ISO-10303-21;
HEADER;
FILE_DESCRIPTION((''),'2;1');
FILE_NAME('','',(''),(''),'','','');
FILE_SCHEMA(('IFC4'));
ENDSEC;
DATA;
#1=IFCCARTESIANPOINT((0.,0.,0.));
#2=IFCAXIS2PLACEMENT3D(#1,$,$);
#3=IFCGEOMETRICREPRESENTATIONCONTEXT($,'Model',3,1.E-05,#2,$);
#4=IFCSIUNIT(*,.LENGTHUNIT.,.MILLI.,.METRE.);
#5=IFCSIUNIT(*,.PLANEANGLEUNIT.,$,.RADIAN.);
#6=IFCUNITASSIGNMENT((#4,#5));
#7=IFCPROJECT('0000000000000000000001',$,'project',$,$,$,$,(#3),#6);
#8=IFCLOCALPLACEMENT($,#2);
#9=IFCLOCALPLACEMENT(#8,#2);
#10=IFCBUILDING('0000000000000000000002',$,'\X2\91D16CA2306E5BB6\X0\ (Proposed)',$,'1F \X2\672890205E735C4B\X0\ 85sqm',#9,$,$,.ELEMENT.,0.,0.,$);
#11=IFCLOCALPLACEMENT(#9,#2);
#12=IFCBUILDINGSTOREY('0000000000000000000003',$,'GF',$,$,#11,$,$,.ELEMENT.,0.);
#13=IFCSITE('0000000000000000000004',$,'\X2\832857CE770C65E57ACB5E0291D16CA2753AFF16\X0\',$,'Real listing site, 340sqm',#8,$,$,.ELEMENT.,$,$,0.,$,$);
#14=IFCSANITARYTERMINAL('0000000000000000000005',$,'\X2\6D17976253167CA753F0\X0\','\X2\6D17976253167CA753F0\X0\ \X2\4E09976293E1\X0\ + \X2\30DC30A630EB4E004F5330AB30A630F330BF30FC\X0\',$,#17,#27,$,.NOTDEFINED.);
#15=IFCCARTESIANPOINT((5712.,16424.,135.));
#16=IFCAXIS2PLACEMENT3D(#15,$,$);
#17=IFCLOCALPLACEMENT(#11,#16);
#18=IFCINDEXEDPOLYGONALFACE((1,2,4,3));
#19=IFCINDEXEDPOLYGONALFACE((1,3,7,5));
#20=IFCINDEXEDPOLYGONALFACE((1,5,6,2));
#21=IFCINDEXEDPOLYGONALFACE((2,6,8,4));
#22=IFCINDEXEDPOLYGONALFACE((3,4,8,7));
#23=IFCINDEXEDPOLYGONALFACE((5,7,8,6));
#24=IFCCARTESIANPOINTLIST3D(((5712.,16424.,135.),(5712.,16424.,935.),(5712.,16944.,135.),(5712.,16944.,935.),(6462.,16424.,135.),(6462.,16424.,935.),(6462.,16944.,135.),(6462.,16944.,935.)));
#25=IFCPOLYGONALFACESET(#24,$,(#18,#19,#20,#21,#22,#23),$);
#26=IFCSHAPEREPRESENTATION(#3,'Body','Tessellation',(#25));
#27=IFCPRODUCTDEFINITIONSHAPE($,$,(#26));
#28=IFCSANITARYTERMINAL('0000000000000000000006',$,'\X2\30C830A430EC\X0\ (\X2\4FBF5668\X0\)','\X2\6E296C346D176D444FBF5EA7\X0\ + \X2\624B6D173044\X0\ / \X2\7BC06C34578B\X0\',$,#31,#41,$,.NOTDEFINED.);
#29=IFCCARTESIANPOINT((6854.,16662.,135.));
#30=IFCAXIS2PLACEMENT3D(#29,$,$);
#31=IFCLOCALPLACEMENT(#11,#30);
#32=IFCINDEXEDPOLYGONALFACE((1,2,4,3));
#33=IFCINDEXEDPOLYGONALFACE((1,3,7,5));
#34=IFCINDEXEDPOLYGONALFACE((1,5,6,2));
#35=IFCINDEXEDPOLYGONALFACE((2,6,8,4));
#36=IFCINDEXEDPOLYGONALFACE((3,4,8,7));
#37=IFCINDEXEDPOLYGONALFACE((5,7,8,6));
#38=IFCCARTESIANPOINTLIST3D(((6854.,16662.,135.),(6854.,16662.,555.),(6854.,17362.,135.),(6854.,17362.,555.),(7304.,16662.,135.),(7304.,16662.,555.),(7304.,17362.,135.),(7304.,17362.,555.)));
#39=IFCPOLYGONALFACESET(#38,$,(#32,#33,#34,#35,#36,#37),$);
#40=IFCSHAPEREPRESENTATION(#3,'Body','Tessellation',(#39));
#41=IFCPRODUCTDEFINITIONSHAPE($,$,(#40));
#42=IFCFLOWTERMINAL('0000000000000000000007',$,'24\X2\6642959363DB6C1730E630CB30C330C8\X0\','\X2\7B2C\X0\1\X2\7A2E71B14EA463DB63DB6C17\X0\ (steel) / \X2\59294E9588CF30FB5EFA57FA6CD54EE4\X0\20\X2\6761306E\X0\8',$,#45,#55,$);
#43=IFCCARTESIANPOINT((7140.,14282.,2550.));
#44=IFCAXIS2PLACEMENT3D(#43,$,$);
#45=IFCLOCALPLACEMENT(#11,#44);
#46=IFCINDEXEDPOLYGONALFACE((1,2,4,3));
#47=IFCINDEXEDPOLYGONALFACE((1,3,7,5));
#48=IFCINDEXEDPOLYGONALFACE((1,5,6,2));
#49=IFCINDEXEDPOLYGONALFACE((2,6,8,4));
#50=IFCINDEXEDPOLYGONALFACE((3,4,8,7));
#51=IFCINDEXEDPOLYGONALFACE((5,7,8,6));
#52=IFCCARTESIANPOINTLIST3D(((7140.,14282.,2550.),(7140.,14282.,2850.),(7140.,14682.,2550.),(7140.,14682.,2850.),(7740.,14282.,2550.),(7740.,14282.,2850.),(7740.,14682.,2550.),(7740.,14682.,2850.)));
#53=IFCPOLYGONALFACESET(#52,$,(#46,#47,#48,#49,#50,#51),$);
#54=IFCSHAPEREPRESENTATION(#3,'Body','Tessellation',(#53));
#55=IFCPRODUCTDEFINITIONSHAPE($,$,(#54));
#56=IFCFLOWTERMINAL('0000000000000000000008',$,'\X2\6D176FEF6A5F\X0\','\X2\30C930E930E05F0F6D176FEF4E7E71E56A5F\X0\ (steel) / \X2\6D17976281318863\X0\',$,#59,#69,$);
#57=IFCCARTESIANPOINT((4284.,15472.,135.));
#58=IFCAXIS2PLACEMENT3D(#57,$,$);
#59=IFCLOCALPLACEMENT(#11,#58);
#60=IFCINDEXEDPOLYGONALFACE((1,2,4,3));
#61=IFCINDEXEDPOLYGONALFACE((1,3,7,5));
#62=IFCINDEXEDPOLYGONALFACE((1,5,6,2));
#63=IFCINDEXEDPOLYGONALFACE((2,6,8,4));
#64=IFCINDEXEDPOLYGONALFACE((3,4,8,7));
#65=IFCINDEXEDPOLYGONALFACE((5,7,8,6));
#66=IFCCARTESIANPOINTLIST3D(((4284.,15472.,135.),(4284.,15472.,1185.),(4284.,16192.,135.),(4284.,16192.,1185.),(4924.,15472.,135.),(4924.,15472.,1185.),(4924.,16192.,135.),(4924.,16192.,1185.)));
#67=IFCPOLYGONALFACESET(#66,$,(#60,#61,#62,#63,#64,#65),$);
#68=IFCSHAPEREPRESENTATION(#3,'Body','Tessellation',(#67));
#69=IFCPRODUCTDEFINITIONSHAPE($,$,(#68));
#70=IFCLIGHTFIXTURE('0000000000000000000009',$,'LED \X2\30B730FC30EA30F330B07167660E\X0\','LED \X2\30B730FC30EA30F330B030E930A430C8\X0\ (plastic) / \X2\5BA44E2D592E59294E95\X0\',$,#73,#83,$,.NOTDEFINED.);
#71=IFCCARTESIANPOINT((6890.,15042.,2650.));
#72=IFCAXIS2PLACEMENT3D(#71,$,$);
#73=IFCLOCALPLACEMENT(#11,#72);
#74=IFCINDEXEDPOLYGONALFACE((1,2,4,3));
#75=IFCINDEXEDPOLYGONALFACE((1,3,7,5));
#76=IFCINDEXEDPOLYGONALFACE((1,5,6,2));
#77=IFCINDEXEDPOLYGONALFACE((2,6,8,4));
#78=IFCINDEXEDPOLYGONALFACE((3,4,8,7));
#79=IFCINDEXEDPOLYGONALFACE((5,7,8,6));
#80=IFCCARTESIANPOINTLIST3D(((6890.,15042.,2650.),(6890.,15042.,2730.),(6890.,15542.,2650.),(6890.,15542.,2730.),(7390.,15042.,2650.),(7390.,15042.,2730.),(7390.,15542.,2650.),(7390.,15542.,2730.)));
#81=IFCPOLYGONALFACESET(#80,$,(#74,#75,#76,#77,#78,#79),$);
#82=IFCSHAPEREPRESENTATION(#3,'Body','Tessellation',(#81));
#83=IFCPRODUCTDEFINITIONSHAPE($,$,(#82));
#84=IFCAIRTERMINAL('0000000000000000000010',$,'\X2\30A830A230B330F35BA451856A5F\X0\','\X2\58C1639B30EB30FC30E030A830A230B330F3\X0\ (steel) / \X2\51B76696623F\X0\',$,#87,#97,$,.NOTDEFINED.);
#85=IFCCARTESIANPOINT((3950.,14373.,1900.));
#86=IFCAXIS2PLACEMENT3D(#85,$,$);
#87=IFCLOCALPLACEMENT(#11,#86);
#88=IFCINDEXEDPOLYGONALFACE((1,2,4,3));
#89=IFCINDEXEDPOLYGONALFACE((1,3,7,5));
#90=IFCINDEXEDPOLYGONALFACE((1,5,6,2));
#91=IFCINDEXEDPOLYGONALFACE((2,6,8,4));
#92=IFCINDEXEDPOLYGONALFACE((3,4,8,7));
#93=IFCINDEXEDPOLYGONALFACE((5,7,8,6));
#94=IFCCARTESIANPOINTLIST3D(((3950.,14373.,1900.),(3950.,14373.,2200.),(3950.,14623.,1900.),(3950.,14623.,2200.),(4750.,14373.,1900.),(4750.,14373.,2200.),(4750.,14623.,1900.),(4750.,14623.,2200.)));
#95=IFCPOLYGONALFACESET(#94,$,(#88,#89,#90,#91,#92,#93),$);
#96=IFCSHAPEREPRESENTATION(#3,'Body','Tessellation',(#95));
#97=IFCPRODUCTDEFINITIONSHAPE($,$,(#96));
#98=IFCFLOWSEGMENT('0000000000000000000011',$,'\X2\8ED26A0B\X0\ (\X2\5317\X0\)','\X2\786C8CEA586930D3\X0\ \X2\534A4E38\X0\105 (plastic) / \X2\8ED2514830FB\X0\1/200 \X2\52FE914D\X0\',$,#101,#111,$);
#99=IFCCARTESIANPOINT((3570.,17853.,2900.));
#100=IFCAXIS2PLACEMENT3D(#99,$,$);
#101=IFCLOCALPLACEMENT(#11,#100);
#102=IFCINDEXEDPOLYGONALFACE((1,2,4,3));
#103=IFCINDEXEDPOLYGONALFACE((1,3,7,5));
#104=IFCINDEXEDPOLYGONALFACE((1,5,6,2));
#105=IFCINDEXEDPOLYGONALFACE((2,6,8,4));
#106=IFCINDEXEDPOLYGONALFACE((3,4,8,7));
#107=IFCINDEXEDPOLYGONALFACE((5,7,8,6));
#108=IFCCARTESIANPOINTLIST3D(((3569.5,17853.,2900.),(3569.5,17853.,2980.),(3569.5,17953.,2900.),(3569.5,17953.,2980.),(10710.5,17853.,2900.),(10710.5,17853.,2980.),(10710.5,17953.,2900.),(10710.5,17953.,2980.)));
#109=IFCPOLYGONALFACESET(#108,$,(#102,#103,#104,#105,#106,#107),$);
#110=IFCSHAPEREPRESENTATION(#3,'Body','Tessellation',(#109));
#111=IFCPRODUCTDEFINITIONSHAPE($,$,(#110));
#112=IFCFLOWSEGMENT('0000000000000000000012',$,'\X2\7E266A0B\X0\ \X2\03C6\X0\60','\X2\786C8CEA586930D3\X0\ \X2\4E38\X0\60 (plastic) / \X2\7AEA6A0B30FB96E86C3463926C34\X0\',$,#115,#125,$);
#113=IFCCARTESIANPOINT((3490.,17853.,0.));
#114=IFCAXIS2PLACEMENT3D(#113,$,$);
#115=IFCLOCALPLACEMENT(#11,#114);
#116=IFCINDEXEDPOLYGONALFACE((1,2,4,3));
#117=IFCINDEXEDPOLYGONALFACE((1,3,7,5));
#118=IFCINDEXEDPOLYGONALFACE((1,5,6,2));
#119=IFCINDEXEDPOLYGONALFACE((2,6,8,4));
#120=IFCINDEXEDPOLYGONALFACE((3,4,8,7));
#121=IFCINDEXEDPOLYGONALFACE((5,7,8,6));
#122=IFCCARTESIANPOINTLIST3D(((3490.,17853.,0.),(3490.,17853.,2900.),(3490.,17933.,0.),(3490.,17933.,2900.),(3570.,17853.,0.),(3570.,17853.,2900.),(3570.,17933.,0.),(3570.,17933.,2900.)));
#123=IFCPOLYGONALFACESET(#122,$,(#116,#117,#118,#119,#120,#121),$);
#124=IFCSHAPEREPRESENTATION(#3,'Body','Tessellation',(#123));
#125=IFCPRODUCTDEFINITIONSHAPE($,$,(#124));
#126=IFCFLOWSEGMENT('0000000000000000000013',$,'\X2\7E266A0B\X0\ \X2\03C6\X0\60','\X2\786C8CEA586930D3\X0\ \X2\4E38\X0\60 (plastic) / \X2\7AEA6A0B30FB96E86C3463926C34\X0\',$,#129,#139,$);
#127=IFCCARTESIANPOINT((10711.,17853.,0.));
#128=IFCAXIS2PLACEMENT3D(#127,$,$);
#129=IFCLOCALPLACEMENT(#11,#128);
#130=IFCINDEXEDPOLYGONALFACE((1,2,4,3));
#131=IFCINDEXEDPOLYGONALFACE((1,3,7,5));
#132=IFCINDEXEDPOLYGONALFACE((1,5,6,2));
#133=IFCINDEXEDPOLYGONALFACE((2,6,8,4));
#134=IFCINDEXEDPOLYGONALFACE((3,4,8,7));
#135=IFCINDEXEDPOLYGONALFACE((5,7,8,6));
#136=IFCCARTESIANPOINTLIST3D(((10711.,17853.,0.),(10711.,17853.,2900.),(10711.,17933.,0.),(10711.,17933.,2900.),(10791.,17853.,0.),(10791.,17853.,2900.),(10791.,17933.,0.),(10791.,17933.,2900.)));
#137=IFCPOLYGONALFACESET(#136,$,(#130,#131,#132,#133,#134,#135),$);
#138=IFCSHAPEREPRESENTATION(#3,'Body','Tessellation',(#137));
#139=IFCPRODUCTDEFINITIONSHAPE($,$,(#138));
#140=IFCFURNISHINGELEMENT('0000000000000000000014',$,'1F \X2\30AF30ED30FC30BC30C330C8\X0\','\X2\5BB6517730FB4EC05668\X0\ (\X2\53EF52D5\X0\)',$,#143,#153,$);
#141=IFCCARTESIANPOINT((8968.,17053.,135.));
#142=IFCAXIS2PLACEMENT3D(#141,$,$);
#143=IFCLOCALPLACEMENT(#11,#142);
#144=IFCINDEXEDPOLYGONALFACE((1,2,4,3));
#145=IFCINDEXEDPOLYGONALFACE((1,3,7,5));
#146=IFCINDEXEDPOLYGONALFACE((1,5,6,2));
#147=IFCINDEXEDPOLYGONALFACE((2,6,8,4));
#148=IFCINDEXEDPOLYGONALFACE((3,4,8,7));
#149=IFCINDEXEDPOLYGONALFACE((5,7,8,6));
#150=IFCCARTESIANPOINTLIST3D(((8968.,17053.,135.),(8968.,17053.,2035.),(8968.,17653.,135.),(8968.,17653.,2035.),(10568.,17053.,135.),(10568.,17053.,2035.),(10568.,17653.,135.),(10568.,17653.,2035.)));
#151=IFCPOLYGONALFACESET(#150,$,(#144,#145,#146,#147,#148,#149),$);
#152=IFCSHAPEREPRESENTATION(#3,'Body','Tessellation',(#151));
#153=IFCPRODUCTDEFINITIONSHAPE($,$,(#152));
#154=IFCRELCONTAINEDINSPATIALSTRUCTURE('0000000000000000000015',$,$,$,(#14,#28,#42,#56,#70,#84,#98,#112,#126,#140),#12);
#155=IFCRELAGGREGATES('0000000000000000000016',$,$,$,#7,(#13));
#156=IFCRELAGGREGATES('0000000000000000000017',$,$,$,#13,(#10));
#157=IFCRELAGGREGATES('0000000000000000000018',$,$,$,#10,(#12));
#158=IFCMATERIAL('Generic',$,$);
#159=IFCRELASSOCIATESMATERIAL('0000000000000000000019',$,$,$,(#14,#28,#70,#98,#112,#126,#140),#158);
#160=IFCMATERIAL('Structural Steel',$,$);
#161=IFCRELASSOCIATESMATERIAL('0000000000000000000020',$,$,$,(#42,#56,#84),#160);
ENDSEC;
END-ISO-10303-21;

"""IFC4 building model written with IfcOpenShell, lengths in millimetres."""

from ifc_helpers import new_model, si_unit, frame, frame_2d, origin, place, context, project, spatial, rectangle, extrude, material, element, save


model = new_model("IFC4")

# Units and contexts
model_context = context("Model", 3, precision=1e-05, world=origin())
ifc_project = project(units=[si_unit("LENGTHUNIT", "METRE", prefix="MILLI"), si_unit("PLANEANGLEUNIT", "RADIAN")], contexts=[model_context])

# Site, building, storey
site_placement = place(None, origin())
site = spatial("IfcSite", under=ifc_project, at=site_placement, Name="茨城県日立市金沢町６", ObjectType="Real listing site, 340sqm", CompositionType="ELEMENT", RefElevation=0.0)
building_placement = place(site_placement, origin())
building = spatial("IfcBuilding", under=site, at=building_placement, Name="金沢の家 (Proposed)", ObjectType="1F 木造平屋 85sqm", CompositionType="ELEMENT", ElevationOfRefHeight=0.0, ElevationOfTerrain=0.0)
storey_placement = place(building_placement, origin())
storey = spatial("IfcBuildingStorey", under=building, at=storey_placement, Name="GF", CompositionType="ELEMENT", Elevation=0.0)

# Shared definitions
ifc_material_1 = material(Name="Generic")

# Sanitary terminals
sanitary_terminal_1_placement = place(storey_placement, frame((5712.0, 16424.0, 135.0)))
element("IfcSanitaryTerminal", 1, at=sanitary_terminal_1_placement, inside=storey, material=ifc_material_1, Name="洗面化粧台", Description="洗面化粧台 三面鏡 + ボウル一体カウンター", PredefinedType="NOTDEFINED", context=model_context, shape_type="SweptSolid", body=[
    extrude(rectangle(XDim=750.0, YDim=520.0, at=frame_2d((375.0, 260.0))), frame((5712.0, 16424.0, 135.0)), (0.0, 0.0, 1.0), 800.0),
])
sanitary_terminal_2_placement = place(storey_placement, frame((6854.0, 16662.0, 135.0)))
element("IfcSanitaryTerminal", 2, at=sanitary_terminal_2_placement, inside=storey, material=ifc_material_1, Name="トイレ (便器)", Description="温水洗浄便座 + 手洗い / 節水型", PredefinedType="NOTDEFINED", context=model_context, shape_type="SweptSolid", body=[
    extrude(rectangle(XDim=450.0, YDim=700.0, at=frame_2d((225.0, 350.0))), frame((6854.0, 16662.0, 135.0)), (0.0, 0.0, 1.0), 420.0),
])

# Flow terminals
ifc_material_2 = material(Name="Structural Steel")
flow_terminal_1_placement = place(storey_placement, frame((7140.0, 14282.0, 2550.0)))
element("IfcFlowTerminal", 3, at=flow_terminal_1_placement, inside=storey, material=ifc_material_2, Name="24時間換気ユニット", Description="第1種熱交換換気 (steel) / 天井裏・建基法令20条の8", context=model_context, shape_type="SweptSolid", body=[
    extrude(rectangle(XDim=600.0, YDim=400.0, at=frame_2d((300.0, 200.0))), frame((7140.0, 14282.0, 2550.0)), (0.0, 0.0, 1.0), 300.0),
])
flow_terminal_2_placement = place(storey_placement, frame((4284.0, 15472.0, 135.0)))
element("IfcFlowTerminal", 4, at=flow_terminal_2_placement, inside=storey, material=ifc_material_2, Name="洗濯機", Description="ドラム式洗濯乾燥機 (steel) / 洗面脱衣", context=model_context, shape_type="SweptSolid", body=[
    extrude(rectangle(XDim=640.0, YDim=720.0, at=frame_2d((320.0, 360.0))), frame((4284.0, 15472.0, 135.0)), (0.0, 0.0, 1.0), 1050.0),
])

# Light fixture
light_fixture_placement = place(storey_placement, frame((6890.0, 15042.0, 2650.0)))
element("IfcLightFixture", 5, at=light_fixture_placement, inside=storey, material=ifc_material_1, Name="LED シーリング照明", Description="LED シーリングライト (plastic) / 室中央天井", PredefinedType="NOTDEFINED", context=model_context, shape_type="SweptSolid", body=[
    extrude(rectangle(XDim=500.0, YDim=500.0, at=frame_2d((250.0, 250.0))), frame((6890.0, 15042.0, 2650.0)), (0.0, 0.0, 1.0), 80.0),
])

# Air terminal
air_terminal_placement = place(storey_placement, frame((3950.0, 14373.0, 1900.0)))
element("IfcAirTerminal", 6, at=air_terminal_placement, inside=storey, material=ifc_material_2, Name="エアコン室内機", Description="壁掛ルームエアコン (steel) / 冷暖房", PredefinedType="NOTDEFINED", context=model_context, shape_type="SweptSolid", body=[
    extrude(rectangle(XDim=800.0, YDim=250.0, at=frame_2d((400.0, 125.0))), frame((3950.0, 14373.0, 1900.0)), (0.0, 0.0, 1.0), 300.0),
])

# Flow segments
flow_segment_1_placement = place(storey_placement, frame((3570.0, 17853.0, 2900.0)))
element("IfcFlowSegment", 7, at=flow_segment_1_placement, inside=storey, material=ifc_material_1, Name="軒樋 (北)", Description="硬質塩ビ 半丸105 (plastic) / 軒先・1/200 勾配", context=model_context, shape_type="SweptSolid", body=[
    extrude(rectangle(XDim=7141.0, YDim=100.0, at=frame_2d((3570.0, 50.0))), frame((3570.0, 17853.0, 2900.0)), (0.0, 0.0, 1.0), 80.0),
])
flow_segment_2_placement = place(storey_placement, frame((3490.0, 17853.0, 0.0)))
element("IfcFlowSegment", 8, at=flow_segment_2_placement, inside=storey, material=ifc_material_1, Name="縦樋 φ60", Description="硬質塩ビ 丸60 (plastic) / 竪樋・雨水排水", context=model_context, shape_type="SweptSolid", body=[
    extrude(rectangle(XDim=80.0, YDim=80.0, at=frame_2d((40.0, 40.0))), frame((3490.0, 17853.0, 0.0)), (0.0, 0.0, 1.0), 2900.0),
])
flow_segment_3_placement = place(storey_placement, frame((10711.0, 17853.0, 0.0)))
element("IfcFlowSegment", 9, at=flow_segment_3_placement, inside=storey, material=ifc_material_1, Name="縦樋 φ60", Description="硬質塩ビ 丸60 (plastic) / 竪樋・雨水排水", context=model_context, shape_type="SweptSolid", body=[
    extrude(rectangle(XDim=80.0, YDim=80.0, at=frame_2d((40.0, 40.0))), frame((10711.0, 17853.0, 0.0)), (0.0, 0.0, 1.0), 2900.0),
])

# Furnishing element
furnishing_placement = place(storey_placement, frame((8968.0, 17053.0, 135.0)))
element("IfcFurnishingElement", 10, at=furnishing_placement, inside=storey, material=ifc_material_1, Name="1F クローゼット", Description="家具・什器 (可動)", context=model_context, shape_type="SweptSolid", body=[
    extrude(rectangle(XDim=1600.0, YDim=600.0, at=frame_2d((800.0, 300.0))), frame((8968.0, 17053.0, 135.0)), (0.0, 0.0, 1.0), 1900.0),
])

save(model, "model.ifc")
